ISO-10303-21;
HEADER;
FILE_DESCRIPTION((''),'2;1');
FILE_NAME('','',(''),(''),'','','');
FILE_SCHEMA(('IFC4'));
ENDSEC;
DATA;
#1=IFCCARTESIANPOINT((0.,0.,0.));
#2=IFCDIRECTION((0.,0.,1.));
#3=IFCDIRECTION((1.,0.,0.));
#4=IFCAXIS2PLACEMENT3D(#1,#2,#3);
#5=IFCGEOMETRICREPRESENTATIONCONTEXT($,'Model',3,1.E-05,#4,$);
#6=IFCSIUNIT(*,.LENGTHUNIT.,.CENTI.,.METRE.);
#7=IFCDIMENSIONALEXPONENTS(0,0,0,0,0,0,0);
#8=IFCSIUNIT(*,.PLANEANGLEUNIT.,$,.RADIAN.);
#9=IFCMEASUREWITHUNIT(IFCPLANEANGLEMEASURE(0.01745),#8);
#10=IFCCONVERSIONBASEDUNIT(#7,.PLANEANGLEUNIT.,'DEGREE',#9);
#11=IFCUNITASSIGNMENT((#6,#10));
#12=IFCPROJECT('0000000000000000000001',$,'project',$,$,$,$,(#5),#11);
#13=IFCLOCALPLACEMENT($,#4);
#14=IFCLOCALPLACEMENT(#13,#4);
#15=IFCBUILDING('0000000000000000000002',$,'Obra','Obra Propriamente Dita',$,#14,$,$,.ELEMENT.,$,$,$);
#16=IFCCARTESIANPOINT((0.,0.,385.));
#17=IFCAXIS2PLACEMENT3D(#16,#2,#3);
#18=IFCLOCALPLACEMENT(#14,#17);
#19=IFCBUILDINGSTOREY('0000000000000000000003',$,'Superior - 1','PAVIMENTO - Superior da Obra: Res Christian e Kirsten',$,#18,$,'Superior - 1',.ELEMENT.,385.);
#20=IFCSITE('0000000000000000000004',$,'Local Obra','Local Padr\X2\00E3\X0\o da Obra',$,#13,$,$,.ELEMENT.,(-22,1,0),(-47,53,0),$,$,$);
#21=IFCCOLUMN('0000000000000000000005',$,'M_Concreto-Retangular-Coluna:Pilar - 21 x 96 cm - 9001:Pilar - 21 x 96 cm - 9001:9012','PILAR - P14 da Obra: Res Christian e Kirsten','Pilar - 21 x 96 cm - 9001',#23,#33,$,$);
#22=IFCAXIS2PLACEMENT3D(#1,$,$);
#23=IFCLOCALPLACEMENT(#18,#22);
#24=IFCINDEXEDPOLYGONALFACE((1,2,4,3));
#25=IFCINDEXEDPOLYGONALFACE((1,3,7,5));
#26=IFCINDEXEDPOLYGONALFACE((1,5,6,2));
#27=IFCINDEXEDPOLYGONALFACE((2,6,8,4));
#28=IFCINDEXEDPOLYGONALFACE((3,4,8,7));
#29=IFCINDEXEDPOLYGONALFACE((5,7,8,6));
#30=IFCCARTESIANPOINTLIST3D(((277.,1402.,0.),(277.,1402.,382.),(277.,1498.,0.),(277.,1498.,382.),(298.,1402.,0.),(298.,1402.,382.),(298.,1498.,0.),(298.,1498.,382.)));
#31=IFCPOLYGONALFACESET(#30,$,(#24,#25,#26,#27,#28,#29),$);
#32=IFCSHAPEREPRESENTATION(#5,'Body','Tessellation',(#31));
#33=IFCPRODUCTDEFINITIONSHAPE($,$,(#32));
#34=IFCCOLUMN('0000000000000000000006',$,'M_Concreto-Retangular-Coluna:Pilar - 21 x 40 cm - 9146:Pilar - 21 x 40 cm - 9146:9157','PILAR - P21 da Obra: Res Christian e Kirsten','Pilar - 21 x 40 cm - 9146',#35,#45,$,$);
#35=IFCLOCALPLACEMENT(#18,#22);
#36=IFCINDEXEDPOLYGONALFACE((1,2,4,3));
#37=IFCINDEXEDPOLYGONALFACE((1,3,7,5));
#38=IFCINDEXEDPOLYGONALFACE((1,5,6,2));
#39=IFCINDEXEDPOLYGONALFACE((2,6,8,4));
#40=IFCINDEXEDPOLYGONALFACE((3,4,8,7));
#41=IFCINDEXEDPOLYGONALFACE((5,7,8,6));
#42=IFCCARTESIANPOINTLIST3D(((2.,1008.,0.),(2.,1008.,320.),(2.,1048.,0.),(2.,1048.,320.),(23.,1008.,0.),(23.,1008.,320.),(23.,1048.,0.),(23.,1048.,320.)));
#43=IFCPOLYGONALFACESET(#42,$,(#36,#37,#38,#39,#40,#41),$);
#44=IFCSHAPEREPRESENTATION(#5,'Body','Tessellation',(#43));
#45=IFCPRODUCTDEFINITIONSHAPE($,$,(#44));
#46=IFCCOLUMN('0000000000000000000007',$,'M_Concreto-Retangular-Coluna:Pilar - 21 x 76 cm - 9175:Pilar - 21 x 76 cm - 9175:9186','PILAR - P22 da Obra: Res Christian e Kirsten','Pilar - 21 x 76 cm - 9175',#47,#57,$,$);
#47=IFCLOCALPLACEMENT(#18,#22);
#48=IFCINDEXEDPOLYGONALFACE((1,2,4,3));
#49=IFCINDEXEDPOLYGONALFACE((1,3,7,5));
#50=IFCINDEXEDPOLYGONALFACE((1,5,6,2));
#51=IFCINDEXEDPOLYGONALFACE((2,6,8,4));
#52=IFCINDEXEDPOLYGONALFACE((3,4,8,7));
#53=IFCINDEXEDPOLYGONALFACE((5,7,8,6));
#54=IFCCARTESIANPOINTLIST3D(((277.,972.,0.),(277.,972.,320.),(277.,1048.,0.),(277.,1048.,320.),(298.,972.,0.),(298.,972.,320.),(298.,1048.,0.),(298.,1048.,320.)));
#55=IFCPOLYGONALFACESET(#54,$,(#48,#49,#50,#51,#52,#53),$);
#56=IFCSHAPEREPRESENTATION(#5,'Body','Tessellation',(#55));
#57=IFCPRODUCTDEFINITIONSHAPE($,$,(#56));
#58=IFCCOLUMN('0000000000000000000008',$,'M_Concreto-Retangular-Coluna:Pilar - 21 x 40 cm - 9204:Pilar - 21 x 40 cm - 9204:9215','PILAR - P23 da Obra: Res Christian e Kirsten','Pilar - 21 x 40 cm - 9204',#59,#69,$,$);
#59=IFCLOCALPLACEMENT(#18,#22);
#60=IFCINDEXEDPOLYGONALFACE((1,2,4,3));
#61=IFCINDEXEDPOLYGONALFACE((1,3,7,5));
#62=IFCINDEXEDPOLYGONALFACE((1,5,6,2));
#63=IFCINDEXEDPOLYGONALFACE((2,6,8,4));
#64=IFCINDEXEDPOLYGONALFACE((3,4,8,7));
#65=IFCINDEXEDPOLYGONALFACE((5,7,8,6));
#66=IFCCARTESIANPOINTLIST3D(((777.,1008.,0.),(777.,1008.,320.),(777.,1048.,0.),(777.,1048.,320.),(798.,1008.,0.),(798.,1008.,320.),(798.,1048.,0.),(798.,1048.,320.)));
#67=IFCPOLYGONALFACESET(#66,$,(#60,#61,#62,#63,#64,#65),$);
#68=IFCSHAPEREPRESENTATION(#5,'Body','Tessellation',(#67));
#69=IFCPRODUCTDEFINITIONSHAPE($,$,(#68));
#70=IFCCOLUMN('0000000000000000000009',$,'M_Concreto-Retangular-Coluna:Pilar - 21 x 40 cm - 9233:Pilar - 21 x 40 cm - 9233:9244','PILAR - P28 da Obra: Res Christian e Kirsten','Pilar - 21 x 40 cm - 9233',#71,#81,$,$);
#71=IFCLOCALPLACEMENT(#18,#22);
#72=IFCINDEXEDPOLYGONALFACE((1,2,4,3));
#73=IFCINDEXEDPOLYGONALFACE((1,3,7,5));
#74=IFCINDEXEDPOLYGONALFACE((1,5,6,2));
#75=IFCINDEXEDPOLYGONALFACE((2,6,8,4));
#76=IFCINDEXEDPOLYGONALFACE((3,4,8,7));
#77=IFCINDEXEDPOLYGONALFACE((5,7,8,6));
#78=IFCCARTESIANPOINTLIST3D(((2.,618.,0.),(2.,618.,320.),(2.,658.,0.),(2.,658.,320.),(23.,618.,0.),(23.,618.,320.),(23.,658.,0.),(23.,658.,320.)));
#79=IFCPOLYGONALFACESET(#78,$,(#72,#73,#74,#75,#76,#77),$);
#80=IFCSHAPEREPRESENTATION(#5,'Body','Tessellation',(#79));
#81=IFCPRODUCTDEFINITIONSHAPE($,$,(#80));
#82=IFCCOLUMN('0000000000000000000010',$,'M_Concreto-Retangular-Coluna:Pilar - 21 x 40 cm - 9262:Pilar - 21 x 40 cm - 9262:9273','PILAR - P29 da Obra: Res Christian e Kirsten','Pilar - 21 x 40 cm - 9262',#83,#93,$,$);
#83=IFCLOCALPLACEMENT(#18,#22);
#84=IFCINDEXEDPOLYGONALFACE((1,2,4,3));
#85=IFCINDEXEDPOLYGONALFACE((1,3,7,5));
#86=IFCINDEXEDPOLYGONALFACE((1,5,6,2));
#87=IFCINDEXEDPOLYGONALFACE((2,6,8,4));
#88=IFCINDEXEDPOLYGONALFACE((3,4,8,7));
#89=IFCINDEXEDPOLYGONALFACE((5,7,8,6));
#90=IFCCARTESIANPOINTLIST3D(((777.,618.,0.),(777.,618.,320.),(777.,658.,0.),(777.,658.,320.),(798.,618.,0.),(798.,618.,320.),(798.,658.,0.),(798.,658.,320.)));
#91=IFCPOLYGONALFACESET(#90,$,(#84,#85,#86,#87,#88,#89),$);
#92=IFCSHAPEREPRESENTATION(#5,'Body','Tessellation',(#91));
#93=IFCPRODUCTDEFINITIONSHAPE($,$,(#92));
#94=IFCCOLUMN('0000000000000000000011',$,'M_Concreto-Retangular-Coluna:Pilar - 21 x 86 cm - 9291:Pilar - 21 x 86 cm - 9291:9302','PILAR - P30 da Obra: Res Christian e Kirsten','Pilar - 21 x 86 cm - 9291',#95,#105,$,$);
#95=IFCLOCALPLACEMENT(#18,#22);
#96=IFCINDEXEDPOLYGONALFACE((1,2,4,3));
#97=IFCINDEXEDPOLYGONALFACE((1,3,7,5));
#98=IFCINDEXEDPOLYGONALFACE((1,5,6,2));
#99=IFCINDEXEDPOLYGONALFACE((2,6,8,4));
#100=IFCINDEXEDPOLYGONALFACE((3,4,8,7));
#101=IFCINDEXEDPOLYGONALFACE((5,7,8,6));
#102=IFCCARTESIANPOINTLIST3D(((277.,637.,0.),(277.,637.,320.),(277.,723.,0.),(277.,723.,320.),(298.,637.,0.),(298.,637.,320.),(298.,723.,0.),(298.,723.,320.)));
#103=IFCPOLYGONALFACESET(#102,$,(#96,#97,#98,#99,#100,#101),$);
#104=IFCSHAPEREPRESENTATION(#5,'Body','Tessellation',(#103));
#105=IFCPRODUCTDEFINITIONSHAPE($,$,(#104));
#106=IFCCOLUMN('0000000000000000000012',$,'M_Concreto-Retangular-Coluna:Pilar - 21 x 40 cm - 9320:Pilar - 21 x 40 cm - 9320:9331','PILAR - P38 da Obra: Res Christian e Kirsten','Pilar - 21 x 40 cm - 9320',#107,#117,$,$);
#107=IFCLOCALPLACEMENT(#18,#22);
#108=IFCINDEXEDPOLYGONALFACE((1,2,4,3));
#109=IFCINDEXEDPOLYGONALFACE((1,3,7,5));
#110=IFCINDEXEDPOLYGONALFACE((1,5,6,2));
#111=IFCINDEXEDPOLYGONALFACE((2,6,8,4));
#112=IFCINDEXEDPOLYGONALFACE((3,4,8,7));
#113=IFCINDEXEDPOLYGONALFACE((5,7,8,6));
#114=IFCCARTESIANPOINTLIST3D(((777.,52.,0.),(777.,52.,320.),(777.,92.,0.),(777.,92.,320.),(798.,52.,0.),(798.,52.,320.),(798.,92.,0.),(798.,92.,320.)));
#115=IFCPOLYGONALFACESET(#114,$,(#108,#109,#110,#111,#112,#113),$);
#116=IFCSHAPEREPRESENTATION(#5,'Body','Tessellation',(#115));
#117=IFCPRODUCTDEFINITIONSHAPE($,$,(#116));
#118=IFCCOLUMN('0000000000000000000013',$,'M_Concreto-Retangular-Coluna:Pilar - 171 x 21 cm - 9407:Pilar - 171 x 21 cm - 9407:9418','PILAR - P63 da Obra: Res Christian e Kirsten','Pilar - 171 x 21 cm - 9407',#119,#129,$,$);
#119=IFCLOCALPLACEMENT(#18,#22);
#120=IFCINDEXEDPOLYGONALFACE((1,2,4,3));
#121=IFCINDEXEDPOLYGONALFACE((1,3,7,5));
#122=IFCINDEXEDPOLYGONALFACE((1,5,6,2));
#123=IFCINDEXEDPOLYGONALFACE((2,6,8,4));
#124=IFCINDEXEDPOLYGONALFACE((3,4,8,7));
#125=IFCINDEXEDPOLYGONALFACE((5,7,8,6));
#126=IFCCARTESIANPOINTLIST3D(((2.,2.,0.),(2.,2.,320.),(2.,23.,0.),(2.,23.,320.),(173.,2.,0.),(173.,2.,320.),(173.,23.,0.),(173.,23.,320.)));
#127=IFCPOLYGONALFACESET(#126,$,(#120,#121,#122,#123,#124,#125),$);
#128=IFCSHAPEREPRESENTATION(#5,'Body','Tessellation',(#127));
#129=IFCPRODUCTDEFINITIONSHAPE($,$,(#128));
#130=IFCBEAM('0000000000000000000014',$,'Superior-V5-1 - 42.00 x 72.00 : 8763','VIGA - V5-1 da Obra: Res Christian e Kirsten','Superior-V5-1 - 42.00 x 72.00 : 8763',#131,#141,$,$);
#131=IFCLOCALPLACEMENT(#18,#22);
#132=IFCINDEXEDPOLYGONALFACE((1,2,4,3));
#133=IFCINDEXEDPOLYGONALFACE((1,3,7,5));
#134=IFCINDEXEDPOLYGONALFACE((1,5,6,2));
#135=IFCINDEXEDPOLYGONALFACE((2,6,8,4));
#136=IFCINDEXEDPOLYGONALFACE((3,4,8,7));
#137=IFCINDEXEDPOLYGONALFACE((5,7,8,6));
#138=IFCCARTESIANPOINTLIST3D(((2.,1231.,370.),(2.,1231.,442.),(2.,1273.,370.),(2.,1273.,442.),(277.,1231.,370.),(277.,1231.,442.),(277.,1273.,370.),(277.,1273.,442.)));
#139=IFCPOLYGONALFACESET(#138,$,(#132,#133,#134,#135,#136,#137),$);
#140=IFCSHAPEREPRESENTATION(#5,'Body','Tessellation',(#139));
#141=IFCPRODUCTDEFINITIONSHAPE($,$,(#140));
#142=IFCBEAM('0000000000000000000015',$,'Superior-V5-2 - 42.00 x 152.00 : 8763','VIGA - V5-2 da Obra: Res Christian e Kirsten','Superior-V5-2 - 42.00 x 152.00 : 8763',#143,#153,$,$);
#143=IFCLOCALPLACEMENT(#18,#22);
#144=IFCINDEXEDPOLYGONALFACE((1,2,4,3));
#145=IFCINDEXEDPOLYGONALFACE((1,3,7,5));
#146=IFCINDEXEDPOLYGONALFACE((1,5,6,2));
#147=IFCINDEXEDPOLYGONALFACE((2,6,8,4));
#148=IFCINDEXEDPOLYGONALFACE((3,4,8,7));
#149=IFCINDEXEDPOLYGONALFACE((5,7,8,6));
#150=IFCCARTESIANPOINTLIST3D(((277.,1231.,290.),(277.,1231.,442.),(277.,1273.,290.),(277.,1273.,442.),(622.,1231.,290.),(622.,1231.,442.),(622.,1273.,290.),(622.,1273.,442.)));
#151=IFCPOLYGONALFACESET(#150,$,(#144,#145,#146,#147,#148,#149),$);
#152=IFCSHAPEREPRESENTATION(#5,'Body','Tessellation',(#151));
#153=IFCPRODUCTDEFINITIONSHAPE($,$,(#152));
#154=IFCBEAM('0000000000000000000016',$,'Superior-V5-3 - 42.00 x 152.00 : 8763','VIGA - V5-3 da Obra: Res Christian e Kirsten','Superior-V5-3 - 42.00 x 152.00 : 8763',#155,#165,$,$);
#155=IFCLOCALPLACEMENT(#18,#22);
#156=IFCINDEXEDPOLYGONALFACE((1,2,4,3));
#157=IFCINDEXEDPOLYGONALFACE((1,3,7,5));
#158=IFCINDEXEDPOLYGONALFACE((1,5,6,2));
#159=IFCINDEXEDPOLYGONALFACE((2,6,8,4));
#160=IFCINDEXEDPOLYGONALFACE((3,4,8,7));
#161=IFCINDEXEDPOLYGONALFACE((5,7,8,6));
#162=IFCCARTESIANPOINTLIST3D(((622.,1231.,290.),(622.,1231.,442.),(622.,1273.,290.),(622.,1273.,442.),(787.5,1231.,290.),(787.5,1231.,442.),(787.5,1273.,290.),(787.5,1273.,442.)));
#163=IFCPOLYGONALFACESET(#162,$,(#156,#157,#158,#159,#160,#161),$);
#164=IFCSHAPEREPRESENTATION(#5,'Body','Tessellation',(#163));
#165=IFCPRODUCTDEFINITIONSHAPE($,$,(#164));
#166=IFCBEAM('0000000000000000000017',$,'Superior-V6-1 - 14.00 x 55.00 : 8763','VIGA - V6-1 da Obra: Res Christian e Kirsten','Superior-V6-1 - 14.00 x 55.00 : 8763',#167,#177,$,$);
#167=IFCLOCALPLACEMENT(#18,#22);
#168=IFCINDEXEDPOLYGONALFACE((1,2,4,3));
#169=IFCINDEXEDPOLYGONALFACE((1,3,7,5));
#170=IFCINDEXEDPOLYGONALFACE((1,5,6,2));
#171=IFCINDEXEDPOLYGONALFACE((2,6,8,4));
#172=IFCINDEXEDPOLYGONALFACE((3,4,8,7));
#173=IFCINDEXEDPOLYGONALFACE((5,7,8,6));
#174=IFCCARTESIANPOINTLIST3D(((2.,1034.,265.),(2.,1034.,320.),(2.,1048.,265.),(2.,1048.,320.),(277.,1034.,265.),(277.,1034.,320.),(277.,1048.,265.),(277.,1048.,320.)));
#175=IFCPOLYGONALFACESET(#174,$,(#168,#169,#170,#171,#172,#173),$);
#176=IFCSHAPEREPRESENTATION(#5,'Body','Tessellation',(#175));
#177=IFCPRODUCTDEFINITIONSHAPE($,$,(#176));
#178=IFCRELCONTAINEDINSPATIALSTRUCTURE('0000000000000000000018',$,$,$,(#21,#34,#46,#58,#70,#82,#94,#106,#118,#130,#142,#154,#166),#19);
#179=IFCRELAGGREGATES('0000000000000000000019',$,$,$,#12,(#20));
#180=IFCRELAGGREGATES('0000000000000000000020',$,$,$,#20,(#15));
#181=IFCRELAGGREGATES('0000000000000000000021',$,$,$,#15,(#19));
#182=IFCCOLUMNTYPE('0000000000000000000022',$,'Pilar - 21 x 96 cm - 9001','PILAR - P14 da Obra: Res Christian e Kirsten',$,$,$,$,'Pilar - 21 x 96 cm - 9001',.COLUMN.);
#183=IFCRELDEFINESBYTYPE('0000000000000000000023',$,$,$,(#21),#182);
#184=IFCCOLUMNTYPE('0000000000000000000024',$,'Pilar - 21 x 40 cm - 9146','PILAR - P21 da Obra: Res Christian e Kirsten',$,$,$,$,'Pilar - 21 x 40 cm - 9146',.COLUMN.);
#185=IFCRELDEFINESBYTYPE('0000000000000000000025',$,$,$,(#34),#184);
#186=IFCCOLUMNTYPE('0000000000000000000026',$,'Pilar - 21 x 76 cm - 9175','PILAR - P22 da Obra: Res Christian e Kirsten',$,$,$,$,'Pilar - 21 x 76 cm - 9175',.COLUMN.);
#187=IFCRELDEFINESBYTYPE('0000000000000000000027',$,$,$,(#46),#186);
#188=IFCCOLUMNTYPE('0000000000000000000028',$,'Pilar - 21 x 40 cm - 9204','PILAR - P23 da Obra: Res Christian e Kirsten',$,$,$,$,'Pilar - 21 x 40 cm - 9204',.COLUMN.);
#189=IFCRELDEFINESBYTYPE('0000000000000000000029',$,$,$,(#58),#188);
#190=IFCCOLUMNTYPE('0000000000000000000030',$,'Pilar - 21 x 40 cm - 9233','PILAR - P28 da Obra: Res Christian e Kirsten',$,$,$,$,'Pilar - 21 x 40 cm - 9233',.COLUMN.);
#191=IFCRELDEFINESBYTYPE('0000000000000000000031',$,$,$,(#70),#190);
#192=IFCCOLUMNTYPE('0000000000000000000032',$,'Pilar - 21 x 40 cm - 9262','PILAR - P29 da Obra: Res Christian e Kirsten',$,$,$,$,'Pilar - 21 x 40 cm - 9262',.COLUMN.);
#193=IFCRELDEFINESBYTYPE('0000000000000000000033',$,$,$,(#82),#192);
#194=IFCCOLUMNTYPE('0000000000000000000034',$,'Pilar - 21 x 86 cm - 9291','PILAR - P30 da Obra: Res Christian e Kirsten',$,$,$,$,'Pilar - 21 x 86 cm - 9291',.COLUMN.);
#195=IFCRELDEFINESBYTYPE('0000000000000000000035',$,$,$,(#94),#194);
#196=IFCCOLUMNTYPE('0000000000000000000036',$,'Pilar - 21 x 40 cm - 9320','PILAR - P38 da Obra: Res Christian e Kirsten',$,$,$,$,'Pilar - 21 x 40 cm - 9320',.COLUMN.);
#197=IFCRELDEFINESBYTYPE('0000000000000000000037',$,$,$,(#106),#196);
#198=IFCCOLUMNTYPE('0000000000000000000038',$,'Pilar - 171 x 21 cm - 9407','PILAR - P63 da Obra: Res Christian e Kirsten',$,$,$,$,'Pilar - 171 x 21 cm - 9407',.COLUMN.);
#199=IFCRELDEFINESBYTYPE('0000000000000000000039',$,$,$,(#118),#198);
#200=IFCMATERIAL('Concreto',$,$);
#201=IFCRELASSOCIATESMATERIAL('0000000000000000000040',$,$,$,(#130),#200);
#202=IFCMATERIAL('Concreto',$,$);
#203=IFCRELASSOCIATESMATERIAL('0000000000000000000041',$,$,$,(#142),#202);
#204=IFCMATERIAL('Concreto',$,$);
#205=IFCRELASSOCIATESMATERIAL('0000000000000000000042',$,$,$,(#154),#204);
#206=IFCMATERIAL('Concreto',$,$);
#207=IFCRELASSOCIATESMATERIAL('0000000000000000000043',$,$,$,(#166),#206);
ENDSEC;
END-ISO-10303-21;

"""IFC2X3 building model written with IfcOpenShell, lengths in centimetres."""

from ifc_helpers import new_model, entity, si_unit, converted_unit, frame, origin, origin_with_axes, origin_2d_with_axis, place, context, project, spatial, polyline, rectangle, outline, extrude, source, transform, mapped, material, type_object, type_shapes, element, save


model = new_model("IFC2X3")

# Units and contexts
model_context = context("Model", 3, precision=1e-05, world=origin_with_axes())
ifc_project = project(units=[si_unit("LENGTHUNIT", "METRE", prefix="CENTI"), converted_unit("PLANEANGLEUNIT", "DEGREE", entity("IfcPlaneAngleMeasure", 0.01745), si_unit("PLANEANGLEUNIT", "RADIAN"), dimensions=[0, 0, 0, 0, 0, 0, 0])], contexts=[model_context])

# Site, building, storey
site_placement = place(None, origin_with_axes())
site = spatial("IfcSite", under=ifc_project, at=site_placement, Name="Local Obra", Description="Local Padrão da Obra", CompositionType="ELEMENT", RefLatitude=(-22, 1, 0), RefLongitude=(-47, 53, 0))
building_placement = place(site_placement, origin_with_axes())
building = spatial("IfcBuilding", under=site, at=building_placement, Name="Obra", Description="Obra Propriamente Dita", CompositionType="ELEMENT")
storey_placement = place(building_placement, frame((0.0, 0.0, 385.0), z_axis=(0.0, 0.0, 1.0), x_axis=(1.0, 0.0, 0.0)))
storey = spatial("IfcBuildingStorey", under=building, at=storey_placement, Name="Superior - 1", Description="PAVIMENTO - Superior da Obra: Res Christian e Kirsten", LongName="Superior - 1", CompositionType="ELEMENT", Elevation=385.0)

# Columns
column_type_1 = type_object("IfcColumnType", Name="Pilar - 21 x 96 cm - 9001", Description="PILAR - P14 da Obra: Res Christian e Kirsten", ElementType="Pilar - 21 x 96 cm - 9001", PredefinedType="COLUMN")
shared_shape_1 = source(origin(), model_context, "Body", "SweptSolid", [
    extrude(rectangle(XDim=21.0, YDim=96.0, at=origin_2d_with_axis()), origin(), (0.0, 0.0, 1.0), 382.0),
])
type_shapes(column_type_1, [shared_shape_1])
column_1_placement = place(storey_placement, frame((287.5, 1450.0, 0.0), z_axis=(0.0, 0.0, 1.0), x_axis=(1.0, 0.0, 0.0)))
element("IfcColumn", 1, at=column_1_placement, inside=storey, type_object=column_type_1, Name="M_Concreto-Retangular-Coluna:Pilar - 21 x 96 cm - 9001:Pilar - 21 x 96 cm - 9001:9012", Description="PILAR - P14 da Obra: Res Christian e Kirsten", ObjectType="Pilar - 21 x 96 cm - 9001", context=model_context, shape_type="MappedRepresentation", body=[
    mapped(shared_shape_1, transform((0.0, 0.0, 0.0), scale=1.0)),
])
column_type_2 = type_object("IfcColumnType", Name="Pilar - 21 x 40 cm - 9146", Description="PILAR - P21 da Obra: Res Christian e Kirsten", ElementType="Pilar - 21 x 40 cm - 9146", PredefinedType="COLUMN")
shared_shape_2 = source(origin(), model_context, "Body", "SweptSolid", [
    extrude(rectangle(XDim=21.0, YDim=40.0, at=origin_2d_with_axis()), origin(), (0.0, 0.0, 1.0), 320.0),
])
type_shapes(column_type_2, [shared_shape_2])
column_2_placement = place(storey_placement, frame((12.5, 1028.0, 0.0), z_axis=(0.0, 0.0, 1.0), x_axis=(1.0, 0.0, 0.0)))
element("IfcColumn", 2, at=column_2_placement, inside=storey, type_object=column_type_2, Name="M_Concreto-Retangular-Coluna:Pilar - 21 x 40 cm - 9146:Pilar - 21 x 40 cm - 9146:9157", Description="PILAR - P21 da Obra: Res Christian e Kirsten", ObjectType="Pilar - 21 x 40 cm - 9146", context=model_context, shape_type="MappedRepresentation", body=[
    mapped(shared_shape_2, transform((0.0, 0.0, 0.0), scale=1.0)),
])
column_type_3 = type_object("IfcColumnType", Name="Pilar - 21 x 76 cm - 9175", Description="PILAR - P22 da Obra: Res Christian e Kirsten", ElementType="Pilar - 21 x 76 cm - 9175", PredefinedType="COLUMN")
shared_shape_3 = source(origin(), model_context, "Body", "SweptSolid", [
    extrude(rectangle(XDim=21.0, YDim=76.0, at=origin_2d_with_axis()), origin(), (0.0, 0.0, 1.0), 320.0),
])
type_shapes(column_type_3, [shared_shape_3])
column_3_placement = place(storey_placement, frame((287.5, 1010.0, 0.0), z_axis=(0.0, 0.0, 1.0), x_axis=(1.0, 0.0, 0.0)))
element("IfcColumn", 3, at=column_3_placement, inside=storey, type_object=column_type_3, Name="M_Concreto-Retangular-Coluna:Pilar - 21 x 76 cm - 9175:Pilar - 21 x 76 cm - 9175:9186", Description="PILAR - P22 da Obra: Res Christian e Kirsten", ObjectType="Pilar - 21 x 76 cm - 9175", context=model_context, shape_type="MappedRepresentation", body=[
    mapped(shared_shape_3, transform((0.0, 0.0, 0.0), scale=1.0)),
])
column_type_4 = type_object("IfcColumnType", Name="Pilar - 21 x 40 cm - 9204", Description="PILAR - P23 da Obra: Res Christian e Kirsten", ElementType="Pilar - 21 x 40 cm - 9204", PredefinedType="COLUMN")
shared_shape_4 = source(origin(), model_context, "Body", "SweptSolid", [
    extrude(rectangle(XDim=21.0, YDim=40.0, at=origin_2d_with_axis()), origin(), (0.0, 0.0, 1.0), 320.0),
])
type_shapes(column_type_4, [shared_shape_4])
column_4_placement = place(storey_placement, frame((787.5, 1028.0, 0.0), z_axis=(0.0, 0.0, 1.0), x_axis=(1.0, 0.0, 0.0)))
element("IfcColumn", 4, at=column_4_placement, inside=storey, type_object=column_type_4, Name="M_Concreto-Retangular-Coluna:Pilar - 21 x 40 cm - 9204:Pilar - 21 x 40 cm - 9204:9215", Description="PILAR - P23 da Obra: Res Christian e Kirsten", ObjectType="Pilar - 21 x 40 cm - 9204", context=model_context, shape_type="MappedRepresentation", body=[
    mapped(shared_shape_4, transform((0.0, 0.0, 0.0), scale=1.0)),
])
column_type_5 = type_object("IfcColumnType", Name="Pilar - 21 x 40 cm - 9233", Description="PILAR - P28 da Obra: Res Christian e Kirsten", ElementType="Pilar - 21 x 40 cm - 9233", PredefinedType="COLUMN")
shared_shape_5 = source(origin(), model_context, "Body", "SweptSolid", [
    extrude(rectangle(XDim=21.0, YDim=40.0, at=origin_2d_with_axis()), origin(), (0.0, 0.0, 1.0), 320.0),
])
type_shapes(column_type_5, [shared_shape_5])
column_5_placement = place(storey_placement, frame((12.5, 638.0, 0.0), z_axis=(0.0, 0.0, 1.0), x_axis=(1.0, 0.0, 0.0)))
element("IfcColumn", 5, at=column_5_placement, inside=storey, type_object=column_type_5, Name="M_Concreto-Retangular-Coluna:Pilar - 21 x 40 cm - 9233:Pilar - 21 x 40 cm - 9233:9244", Description="PILAR - P28 da Obra: Res Christian e Kirsten", ObjectType="Pilar - 21 x 40 cm - 9233", context=model_context, shape_type="MappedRepresentation", body=[
    mapped(shared_shape_5, transform((0.0, 0.0, 0.0), scale=1.0)),
])
column_type_6 = type_object("IfcColumnType", Name="Pilar - 21 x 40 cm - 9262", Description="PILAR - P29 da Obra: Res Christian e Kirsten", ElementType="Pilar - 21 x 40 cm - 9262", PredefinedType="COLUMN")
shared_shape_6 = source(origin(), model_context, "Body", "SweptSolid", [
    extrude(rectangle(XDim=21.0, YDim=40.0, at=origin_2d_with_axis()), origin(), (0.0, 0.0, 1.0), 320.0),
])
type_shapes(column_type_6, [shared_shape_6])
column_6_placement = place(storey_placement, frame((787.5, 638.0, 0.0), z_axis=(0.0, 0.0, 1.0), x_axis=(1.0, 0.0, 0.0)))
element("IfcColumn", 6, at=column_6_placement, inside=storey, type_object=column_type_6, Name="M_Concreto-Retangular-Coluna:Pilar - 21 x 40 cm - 9262:Pilar - 21 x 40 cm - 9262:9273", Description="PILAR - P29 da Obra: Res Christian e Kirsten", ObjectType="Pilar - 21 x 40 cm - 9262", context=model_context, shape_type="MappedRepresentation", body=[
    mapped(shared_shape_6, transform((0.0, 0.0, 0.0), scale=1.0)),
])
column_type_7 = type_object("IfcColumnType", Name="Pilar - 21 x 86 cm - 9291", Description="PILAR - P30 da Obra: Res Christian e Kirsten", ElementType="Pilar - 21 x 86 cm - 9291", PredefinedType="COLUMN")
shared_shape_7 = source(origin(), model_context, "Body", "SweptSolid", [
    extrude(rectangle(XDim=21.0, YDim=86.0, at=origin_2d_with_axis()), origin(), (0.0, 0.0, 1.0), 320.0),
])
type_shapes(column_type_7, [shared_shape_7])
column_7_placement = place(storey_placement, frame((287.5, 680.0, 0.0), z_axis=(0.0, 0.0, 1.0), x_axis=(1.0, 0.0, 0.0)))
element("IfcColumn", 7, at=column_7_placement, inside=storey, type_object=column_type_7, Name="M_Concreto-Retangular-Coluna:Pilar - 21 x 86 cm - 9291:Pilar - 21 x 86 cm - 9291:9302", Description="PILAR - P30 da Obra: Res Christian e Kirsten", ObjectType="Pilar - 21 x 86 cm - 9291", context=model_context, shape_type="MappedRepresentation", body=[
    mapped(shared_shape_7, transform((0.0, 0.0, 0.0), scale=1.0)),
])
column_type_8 = type_object("IfcColumnType", Name="Pilar - 21 x 40 cm - 9320", Description="PILAR - P38 da Obra: Res Christian e Kirsten", ElementType="Pilar - 21 x 40 cm - 9320", PredefinedType="COLUMN")
shared_shape_8 = source(origin(), model_context, "Body", "SweptSolid", [
    extrude(rectangle(XDim=21.0, YDim=40.0, at=origin_2d_with_axis()), origin(), (0.0, 0.0, 1.0), 320.0),
])
type_shapes(column_type_8, [shared_shape_8])
column_8_placement = place(storey_placement, frame((787.5, 72.0, 0.0), z_axis=(0.0, 0.0, 1.0), x_axis=(1.0, 0.0, 0.0)))
element("IfcColumn", 8, at=column_8_placement, inside=storey, type_object=column_type_8, Name="M_Concreto-Retangular-Coluna:Pilar - 21 x 40 cm - 9320:Pilar - 21 x 40 cm - 9320:9331", Description="PILAR - P38 da Obra: Res Christian e Kirsten", ObjectType="Pilar - 21 x 40 cm - 9320", context=model_context, shape_type="MappedRepresentation", body=[
    mapped(shared_shape_8, transform((0.0, 0.0, 0.0), scale=1.0)),
])
column_type_9 = type_object("IfcColumnType", Name="Pilar - 171 x 21 cm - 9407", Description="PILAR - P63 da Obra: Res Christian e Kirsten", ElementType="Pilar - 171 x 21 cm - 9407", PredefinedType="COLUMN")
shared_shape_9 = source(origin(), model_context, "Body", "SweptSolid", [
    extrude(rectangle(XDim=171.0, YDim=21.0, at=origin_2d_with_axis()), origin(), (0.0, 0.0, 1.0), 320.0),
])
type_shapes(column_type_9, [shared_shape_9])
column_9_placement = place(storey_placement, frame((87.5, 12.5, 0.0), z_axis=(0.0, 0.0, 1.0), x_axis=(1.0, 0.0, 0.0)))
element("IfcColumn", 9, at=column_9_placement, inside=storey, type_object=column_type_9, Name="M_Concreto-Retangular-Coluna:Pilar - 171 x 21 cm - 9407:Pilar - 171 x 21 cm - 9407:9418", Description="PILAR - P63 da Obra: Res Christian e Kirsten", ObjectType="Pilar - 171 x 21 cm - 9407", context=model_context, shape_type="MappedRepresentation", body=[
    mapped(shared_shape_9, transform((0.0, 0.0, 0.0), scale=1.0)),
])

# Beams
ifc_material_1 = material(Name="Concreto")
beam_1_placement = place(storey_placement, frame((2.0, 1252.0, 442.0), z_axis=(1.0, 0.0, 0.0), x_axis=(0.0, -1.0, 0.0)))
element("IfcBeam", 10, at=beam_1_placement, inside=storey, material=ifc_material_1, Name="Superior-V5-1 - 42.00 x 72.00 : 8763", Description="VIGA - V5-1 da Obra: Res Christian e Kirsten", ObjectType="Superior-V5-1 - 42.00 x 72.00 : 8763", context=model_context, shape_type="SweptSolid", body=[
    extrude(outline(polyline([(-21.0, 0.0), (21.0, 0.0), (21.0, 72.0), (-21.0, 72.0), (-21.0, 0.0)])), origin_with_axes(), (0.0, 0.0, 1.0), 275.0),
])
ifc_material_2 = material(Name="Concreto")
beam_2_placement = place(storey_placement, frame((277.0, 1252.0, 442.0), z_axis=(1.0, 0.0, 0.0), x_axis=(0.0, -1.0, 0.0)))
element("IfcBeam", 11, at=beam_2_placement, inside=storey, material=ifc_material_2, Name="Superior-V5-2 - 42.00 x 152.00 : 8763", Description="VIGA - V5-2 da Obra: Res Christian e Kirsten", ObjectType="Superior-V5-2 - 42.00 x 152.00 : 8763", context=model_context, shape_type="SweptSolid", body=[
    extrude(outline(polyline([(-21.0, 0.0), (21.0, 0.0), (21.0, 152.0), (-21.0, 152.0), (-21.0, 0.0)])), origin_with_axes(), (0.0, 0.0, 1.0), 345.0),
])
ifc_material_3 = material(Name="Concreto")
beam_3_placement = place(storey_placement, frame((622.0, 1252.0, 442.0), z_axis=(1.0, 0.0, 0.0), x_axis=(0.0, -1.0, 0.0)))
element("IfcBeam", 12, at=beam_3_placement, inside=storey, material=ifc_material_3, Name="Superior-V5-3 - 42.00 x 152.00 : 8763", Description="VIGA - V5-3 da Obra: Res Christian e Kirsten", ObjectType="Superior-V5-3 - 42.00 x 152.00 : 8763", context=model_context, shape_type="SweptSolid", body=[
    extrude(outline(polyline([(-21.0, 0.0), (21.0, 0.0), (21.0, 152.0), (-21.0, 152.0), (-21.0, 0.0)])), origin_with_axes(), (0.0, 0.0, 1.0), 165.5),
])
ifc_material_4 = material(Name="Concreto")
beam_4_placement = place(storey_placement, frame((2.0, 1048.0, 320.0), z_axis=(1.0, 0.0, 0.0), x_axis=(0.0, -1.0, 0.0)))
element("IfcBeam", 13, at=beam_4_placement, inside=storey, material=ifc_material_4, Name="Superior-V6-1 - 14.00 x 55.00 : 8763", Description="VIGA - V6-1 da Obra: Res Christian e Kirsten", ObjectType="Superior-V6-1 - 14.00 x 55.00 : 8763", context=model_context, shape_type="SweptSolid", body=[
    extrude(outline(polyline([(0.0, 0.0), (14.0, 0.0), (14.0, 55.0), (0.0, 55.0), (0.0, 0.0)])), origin_with_axes(), (0.0, 0.0, 1.0), 275.0),
])

save(model, "model.ifc")
